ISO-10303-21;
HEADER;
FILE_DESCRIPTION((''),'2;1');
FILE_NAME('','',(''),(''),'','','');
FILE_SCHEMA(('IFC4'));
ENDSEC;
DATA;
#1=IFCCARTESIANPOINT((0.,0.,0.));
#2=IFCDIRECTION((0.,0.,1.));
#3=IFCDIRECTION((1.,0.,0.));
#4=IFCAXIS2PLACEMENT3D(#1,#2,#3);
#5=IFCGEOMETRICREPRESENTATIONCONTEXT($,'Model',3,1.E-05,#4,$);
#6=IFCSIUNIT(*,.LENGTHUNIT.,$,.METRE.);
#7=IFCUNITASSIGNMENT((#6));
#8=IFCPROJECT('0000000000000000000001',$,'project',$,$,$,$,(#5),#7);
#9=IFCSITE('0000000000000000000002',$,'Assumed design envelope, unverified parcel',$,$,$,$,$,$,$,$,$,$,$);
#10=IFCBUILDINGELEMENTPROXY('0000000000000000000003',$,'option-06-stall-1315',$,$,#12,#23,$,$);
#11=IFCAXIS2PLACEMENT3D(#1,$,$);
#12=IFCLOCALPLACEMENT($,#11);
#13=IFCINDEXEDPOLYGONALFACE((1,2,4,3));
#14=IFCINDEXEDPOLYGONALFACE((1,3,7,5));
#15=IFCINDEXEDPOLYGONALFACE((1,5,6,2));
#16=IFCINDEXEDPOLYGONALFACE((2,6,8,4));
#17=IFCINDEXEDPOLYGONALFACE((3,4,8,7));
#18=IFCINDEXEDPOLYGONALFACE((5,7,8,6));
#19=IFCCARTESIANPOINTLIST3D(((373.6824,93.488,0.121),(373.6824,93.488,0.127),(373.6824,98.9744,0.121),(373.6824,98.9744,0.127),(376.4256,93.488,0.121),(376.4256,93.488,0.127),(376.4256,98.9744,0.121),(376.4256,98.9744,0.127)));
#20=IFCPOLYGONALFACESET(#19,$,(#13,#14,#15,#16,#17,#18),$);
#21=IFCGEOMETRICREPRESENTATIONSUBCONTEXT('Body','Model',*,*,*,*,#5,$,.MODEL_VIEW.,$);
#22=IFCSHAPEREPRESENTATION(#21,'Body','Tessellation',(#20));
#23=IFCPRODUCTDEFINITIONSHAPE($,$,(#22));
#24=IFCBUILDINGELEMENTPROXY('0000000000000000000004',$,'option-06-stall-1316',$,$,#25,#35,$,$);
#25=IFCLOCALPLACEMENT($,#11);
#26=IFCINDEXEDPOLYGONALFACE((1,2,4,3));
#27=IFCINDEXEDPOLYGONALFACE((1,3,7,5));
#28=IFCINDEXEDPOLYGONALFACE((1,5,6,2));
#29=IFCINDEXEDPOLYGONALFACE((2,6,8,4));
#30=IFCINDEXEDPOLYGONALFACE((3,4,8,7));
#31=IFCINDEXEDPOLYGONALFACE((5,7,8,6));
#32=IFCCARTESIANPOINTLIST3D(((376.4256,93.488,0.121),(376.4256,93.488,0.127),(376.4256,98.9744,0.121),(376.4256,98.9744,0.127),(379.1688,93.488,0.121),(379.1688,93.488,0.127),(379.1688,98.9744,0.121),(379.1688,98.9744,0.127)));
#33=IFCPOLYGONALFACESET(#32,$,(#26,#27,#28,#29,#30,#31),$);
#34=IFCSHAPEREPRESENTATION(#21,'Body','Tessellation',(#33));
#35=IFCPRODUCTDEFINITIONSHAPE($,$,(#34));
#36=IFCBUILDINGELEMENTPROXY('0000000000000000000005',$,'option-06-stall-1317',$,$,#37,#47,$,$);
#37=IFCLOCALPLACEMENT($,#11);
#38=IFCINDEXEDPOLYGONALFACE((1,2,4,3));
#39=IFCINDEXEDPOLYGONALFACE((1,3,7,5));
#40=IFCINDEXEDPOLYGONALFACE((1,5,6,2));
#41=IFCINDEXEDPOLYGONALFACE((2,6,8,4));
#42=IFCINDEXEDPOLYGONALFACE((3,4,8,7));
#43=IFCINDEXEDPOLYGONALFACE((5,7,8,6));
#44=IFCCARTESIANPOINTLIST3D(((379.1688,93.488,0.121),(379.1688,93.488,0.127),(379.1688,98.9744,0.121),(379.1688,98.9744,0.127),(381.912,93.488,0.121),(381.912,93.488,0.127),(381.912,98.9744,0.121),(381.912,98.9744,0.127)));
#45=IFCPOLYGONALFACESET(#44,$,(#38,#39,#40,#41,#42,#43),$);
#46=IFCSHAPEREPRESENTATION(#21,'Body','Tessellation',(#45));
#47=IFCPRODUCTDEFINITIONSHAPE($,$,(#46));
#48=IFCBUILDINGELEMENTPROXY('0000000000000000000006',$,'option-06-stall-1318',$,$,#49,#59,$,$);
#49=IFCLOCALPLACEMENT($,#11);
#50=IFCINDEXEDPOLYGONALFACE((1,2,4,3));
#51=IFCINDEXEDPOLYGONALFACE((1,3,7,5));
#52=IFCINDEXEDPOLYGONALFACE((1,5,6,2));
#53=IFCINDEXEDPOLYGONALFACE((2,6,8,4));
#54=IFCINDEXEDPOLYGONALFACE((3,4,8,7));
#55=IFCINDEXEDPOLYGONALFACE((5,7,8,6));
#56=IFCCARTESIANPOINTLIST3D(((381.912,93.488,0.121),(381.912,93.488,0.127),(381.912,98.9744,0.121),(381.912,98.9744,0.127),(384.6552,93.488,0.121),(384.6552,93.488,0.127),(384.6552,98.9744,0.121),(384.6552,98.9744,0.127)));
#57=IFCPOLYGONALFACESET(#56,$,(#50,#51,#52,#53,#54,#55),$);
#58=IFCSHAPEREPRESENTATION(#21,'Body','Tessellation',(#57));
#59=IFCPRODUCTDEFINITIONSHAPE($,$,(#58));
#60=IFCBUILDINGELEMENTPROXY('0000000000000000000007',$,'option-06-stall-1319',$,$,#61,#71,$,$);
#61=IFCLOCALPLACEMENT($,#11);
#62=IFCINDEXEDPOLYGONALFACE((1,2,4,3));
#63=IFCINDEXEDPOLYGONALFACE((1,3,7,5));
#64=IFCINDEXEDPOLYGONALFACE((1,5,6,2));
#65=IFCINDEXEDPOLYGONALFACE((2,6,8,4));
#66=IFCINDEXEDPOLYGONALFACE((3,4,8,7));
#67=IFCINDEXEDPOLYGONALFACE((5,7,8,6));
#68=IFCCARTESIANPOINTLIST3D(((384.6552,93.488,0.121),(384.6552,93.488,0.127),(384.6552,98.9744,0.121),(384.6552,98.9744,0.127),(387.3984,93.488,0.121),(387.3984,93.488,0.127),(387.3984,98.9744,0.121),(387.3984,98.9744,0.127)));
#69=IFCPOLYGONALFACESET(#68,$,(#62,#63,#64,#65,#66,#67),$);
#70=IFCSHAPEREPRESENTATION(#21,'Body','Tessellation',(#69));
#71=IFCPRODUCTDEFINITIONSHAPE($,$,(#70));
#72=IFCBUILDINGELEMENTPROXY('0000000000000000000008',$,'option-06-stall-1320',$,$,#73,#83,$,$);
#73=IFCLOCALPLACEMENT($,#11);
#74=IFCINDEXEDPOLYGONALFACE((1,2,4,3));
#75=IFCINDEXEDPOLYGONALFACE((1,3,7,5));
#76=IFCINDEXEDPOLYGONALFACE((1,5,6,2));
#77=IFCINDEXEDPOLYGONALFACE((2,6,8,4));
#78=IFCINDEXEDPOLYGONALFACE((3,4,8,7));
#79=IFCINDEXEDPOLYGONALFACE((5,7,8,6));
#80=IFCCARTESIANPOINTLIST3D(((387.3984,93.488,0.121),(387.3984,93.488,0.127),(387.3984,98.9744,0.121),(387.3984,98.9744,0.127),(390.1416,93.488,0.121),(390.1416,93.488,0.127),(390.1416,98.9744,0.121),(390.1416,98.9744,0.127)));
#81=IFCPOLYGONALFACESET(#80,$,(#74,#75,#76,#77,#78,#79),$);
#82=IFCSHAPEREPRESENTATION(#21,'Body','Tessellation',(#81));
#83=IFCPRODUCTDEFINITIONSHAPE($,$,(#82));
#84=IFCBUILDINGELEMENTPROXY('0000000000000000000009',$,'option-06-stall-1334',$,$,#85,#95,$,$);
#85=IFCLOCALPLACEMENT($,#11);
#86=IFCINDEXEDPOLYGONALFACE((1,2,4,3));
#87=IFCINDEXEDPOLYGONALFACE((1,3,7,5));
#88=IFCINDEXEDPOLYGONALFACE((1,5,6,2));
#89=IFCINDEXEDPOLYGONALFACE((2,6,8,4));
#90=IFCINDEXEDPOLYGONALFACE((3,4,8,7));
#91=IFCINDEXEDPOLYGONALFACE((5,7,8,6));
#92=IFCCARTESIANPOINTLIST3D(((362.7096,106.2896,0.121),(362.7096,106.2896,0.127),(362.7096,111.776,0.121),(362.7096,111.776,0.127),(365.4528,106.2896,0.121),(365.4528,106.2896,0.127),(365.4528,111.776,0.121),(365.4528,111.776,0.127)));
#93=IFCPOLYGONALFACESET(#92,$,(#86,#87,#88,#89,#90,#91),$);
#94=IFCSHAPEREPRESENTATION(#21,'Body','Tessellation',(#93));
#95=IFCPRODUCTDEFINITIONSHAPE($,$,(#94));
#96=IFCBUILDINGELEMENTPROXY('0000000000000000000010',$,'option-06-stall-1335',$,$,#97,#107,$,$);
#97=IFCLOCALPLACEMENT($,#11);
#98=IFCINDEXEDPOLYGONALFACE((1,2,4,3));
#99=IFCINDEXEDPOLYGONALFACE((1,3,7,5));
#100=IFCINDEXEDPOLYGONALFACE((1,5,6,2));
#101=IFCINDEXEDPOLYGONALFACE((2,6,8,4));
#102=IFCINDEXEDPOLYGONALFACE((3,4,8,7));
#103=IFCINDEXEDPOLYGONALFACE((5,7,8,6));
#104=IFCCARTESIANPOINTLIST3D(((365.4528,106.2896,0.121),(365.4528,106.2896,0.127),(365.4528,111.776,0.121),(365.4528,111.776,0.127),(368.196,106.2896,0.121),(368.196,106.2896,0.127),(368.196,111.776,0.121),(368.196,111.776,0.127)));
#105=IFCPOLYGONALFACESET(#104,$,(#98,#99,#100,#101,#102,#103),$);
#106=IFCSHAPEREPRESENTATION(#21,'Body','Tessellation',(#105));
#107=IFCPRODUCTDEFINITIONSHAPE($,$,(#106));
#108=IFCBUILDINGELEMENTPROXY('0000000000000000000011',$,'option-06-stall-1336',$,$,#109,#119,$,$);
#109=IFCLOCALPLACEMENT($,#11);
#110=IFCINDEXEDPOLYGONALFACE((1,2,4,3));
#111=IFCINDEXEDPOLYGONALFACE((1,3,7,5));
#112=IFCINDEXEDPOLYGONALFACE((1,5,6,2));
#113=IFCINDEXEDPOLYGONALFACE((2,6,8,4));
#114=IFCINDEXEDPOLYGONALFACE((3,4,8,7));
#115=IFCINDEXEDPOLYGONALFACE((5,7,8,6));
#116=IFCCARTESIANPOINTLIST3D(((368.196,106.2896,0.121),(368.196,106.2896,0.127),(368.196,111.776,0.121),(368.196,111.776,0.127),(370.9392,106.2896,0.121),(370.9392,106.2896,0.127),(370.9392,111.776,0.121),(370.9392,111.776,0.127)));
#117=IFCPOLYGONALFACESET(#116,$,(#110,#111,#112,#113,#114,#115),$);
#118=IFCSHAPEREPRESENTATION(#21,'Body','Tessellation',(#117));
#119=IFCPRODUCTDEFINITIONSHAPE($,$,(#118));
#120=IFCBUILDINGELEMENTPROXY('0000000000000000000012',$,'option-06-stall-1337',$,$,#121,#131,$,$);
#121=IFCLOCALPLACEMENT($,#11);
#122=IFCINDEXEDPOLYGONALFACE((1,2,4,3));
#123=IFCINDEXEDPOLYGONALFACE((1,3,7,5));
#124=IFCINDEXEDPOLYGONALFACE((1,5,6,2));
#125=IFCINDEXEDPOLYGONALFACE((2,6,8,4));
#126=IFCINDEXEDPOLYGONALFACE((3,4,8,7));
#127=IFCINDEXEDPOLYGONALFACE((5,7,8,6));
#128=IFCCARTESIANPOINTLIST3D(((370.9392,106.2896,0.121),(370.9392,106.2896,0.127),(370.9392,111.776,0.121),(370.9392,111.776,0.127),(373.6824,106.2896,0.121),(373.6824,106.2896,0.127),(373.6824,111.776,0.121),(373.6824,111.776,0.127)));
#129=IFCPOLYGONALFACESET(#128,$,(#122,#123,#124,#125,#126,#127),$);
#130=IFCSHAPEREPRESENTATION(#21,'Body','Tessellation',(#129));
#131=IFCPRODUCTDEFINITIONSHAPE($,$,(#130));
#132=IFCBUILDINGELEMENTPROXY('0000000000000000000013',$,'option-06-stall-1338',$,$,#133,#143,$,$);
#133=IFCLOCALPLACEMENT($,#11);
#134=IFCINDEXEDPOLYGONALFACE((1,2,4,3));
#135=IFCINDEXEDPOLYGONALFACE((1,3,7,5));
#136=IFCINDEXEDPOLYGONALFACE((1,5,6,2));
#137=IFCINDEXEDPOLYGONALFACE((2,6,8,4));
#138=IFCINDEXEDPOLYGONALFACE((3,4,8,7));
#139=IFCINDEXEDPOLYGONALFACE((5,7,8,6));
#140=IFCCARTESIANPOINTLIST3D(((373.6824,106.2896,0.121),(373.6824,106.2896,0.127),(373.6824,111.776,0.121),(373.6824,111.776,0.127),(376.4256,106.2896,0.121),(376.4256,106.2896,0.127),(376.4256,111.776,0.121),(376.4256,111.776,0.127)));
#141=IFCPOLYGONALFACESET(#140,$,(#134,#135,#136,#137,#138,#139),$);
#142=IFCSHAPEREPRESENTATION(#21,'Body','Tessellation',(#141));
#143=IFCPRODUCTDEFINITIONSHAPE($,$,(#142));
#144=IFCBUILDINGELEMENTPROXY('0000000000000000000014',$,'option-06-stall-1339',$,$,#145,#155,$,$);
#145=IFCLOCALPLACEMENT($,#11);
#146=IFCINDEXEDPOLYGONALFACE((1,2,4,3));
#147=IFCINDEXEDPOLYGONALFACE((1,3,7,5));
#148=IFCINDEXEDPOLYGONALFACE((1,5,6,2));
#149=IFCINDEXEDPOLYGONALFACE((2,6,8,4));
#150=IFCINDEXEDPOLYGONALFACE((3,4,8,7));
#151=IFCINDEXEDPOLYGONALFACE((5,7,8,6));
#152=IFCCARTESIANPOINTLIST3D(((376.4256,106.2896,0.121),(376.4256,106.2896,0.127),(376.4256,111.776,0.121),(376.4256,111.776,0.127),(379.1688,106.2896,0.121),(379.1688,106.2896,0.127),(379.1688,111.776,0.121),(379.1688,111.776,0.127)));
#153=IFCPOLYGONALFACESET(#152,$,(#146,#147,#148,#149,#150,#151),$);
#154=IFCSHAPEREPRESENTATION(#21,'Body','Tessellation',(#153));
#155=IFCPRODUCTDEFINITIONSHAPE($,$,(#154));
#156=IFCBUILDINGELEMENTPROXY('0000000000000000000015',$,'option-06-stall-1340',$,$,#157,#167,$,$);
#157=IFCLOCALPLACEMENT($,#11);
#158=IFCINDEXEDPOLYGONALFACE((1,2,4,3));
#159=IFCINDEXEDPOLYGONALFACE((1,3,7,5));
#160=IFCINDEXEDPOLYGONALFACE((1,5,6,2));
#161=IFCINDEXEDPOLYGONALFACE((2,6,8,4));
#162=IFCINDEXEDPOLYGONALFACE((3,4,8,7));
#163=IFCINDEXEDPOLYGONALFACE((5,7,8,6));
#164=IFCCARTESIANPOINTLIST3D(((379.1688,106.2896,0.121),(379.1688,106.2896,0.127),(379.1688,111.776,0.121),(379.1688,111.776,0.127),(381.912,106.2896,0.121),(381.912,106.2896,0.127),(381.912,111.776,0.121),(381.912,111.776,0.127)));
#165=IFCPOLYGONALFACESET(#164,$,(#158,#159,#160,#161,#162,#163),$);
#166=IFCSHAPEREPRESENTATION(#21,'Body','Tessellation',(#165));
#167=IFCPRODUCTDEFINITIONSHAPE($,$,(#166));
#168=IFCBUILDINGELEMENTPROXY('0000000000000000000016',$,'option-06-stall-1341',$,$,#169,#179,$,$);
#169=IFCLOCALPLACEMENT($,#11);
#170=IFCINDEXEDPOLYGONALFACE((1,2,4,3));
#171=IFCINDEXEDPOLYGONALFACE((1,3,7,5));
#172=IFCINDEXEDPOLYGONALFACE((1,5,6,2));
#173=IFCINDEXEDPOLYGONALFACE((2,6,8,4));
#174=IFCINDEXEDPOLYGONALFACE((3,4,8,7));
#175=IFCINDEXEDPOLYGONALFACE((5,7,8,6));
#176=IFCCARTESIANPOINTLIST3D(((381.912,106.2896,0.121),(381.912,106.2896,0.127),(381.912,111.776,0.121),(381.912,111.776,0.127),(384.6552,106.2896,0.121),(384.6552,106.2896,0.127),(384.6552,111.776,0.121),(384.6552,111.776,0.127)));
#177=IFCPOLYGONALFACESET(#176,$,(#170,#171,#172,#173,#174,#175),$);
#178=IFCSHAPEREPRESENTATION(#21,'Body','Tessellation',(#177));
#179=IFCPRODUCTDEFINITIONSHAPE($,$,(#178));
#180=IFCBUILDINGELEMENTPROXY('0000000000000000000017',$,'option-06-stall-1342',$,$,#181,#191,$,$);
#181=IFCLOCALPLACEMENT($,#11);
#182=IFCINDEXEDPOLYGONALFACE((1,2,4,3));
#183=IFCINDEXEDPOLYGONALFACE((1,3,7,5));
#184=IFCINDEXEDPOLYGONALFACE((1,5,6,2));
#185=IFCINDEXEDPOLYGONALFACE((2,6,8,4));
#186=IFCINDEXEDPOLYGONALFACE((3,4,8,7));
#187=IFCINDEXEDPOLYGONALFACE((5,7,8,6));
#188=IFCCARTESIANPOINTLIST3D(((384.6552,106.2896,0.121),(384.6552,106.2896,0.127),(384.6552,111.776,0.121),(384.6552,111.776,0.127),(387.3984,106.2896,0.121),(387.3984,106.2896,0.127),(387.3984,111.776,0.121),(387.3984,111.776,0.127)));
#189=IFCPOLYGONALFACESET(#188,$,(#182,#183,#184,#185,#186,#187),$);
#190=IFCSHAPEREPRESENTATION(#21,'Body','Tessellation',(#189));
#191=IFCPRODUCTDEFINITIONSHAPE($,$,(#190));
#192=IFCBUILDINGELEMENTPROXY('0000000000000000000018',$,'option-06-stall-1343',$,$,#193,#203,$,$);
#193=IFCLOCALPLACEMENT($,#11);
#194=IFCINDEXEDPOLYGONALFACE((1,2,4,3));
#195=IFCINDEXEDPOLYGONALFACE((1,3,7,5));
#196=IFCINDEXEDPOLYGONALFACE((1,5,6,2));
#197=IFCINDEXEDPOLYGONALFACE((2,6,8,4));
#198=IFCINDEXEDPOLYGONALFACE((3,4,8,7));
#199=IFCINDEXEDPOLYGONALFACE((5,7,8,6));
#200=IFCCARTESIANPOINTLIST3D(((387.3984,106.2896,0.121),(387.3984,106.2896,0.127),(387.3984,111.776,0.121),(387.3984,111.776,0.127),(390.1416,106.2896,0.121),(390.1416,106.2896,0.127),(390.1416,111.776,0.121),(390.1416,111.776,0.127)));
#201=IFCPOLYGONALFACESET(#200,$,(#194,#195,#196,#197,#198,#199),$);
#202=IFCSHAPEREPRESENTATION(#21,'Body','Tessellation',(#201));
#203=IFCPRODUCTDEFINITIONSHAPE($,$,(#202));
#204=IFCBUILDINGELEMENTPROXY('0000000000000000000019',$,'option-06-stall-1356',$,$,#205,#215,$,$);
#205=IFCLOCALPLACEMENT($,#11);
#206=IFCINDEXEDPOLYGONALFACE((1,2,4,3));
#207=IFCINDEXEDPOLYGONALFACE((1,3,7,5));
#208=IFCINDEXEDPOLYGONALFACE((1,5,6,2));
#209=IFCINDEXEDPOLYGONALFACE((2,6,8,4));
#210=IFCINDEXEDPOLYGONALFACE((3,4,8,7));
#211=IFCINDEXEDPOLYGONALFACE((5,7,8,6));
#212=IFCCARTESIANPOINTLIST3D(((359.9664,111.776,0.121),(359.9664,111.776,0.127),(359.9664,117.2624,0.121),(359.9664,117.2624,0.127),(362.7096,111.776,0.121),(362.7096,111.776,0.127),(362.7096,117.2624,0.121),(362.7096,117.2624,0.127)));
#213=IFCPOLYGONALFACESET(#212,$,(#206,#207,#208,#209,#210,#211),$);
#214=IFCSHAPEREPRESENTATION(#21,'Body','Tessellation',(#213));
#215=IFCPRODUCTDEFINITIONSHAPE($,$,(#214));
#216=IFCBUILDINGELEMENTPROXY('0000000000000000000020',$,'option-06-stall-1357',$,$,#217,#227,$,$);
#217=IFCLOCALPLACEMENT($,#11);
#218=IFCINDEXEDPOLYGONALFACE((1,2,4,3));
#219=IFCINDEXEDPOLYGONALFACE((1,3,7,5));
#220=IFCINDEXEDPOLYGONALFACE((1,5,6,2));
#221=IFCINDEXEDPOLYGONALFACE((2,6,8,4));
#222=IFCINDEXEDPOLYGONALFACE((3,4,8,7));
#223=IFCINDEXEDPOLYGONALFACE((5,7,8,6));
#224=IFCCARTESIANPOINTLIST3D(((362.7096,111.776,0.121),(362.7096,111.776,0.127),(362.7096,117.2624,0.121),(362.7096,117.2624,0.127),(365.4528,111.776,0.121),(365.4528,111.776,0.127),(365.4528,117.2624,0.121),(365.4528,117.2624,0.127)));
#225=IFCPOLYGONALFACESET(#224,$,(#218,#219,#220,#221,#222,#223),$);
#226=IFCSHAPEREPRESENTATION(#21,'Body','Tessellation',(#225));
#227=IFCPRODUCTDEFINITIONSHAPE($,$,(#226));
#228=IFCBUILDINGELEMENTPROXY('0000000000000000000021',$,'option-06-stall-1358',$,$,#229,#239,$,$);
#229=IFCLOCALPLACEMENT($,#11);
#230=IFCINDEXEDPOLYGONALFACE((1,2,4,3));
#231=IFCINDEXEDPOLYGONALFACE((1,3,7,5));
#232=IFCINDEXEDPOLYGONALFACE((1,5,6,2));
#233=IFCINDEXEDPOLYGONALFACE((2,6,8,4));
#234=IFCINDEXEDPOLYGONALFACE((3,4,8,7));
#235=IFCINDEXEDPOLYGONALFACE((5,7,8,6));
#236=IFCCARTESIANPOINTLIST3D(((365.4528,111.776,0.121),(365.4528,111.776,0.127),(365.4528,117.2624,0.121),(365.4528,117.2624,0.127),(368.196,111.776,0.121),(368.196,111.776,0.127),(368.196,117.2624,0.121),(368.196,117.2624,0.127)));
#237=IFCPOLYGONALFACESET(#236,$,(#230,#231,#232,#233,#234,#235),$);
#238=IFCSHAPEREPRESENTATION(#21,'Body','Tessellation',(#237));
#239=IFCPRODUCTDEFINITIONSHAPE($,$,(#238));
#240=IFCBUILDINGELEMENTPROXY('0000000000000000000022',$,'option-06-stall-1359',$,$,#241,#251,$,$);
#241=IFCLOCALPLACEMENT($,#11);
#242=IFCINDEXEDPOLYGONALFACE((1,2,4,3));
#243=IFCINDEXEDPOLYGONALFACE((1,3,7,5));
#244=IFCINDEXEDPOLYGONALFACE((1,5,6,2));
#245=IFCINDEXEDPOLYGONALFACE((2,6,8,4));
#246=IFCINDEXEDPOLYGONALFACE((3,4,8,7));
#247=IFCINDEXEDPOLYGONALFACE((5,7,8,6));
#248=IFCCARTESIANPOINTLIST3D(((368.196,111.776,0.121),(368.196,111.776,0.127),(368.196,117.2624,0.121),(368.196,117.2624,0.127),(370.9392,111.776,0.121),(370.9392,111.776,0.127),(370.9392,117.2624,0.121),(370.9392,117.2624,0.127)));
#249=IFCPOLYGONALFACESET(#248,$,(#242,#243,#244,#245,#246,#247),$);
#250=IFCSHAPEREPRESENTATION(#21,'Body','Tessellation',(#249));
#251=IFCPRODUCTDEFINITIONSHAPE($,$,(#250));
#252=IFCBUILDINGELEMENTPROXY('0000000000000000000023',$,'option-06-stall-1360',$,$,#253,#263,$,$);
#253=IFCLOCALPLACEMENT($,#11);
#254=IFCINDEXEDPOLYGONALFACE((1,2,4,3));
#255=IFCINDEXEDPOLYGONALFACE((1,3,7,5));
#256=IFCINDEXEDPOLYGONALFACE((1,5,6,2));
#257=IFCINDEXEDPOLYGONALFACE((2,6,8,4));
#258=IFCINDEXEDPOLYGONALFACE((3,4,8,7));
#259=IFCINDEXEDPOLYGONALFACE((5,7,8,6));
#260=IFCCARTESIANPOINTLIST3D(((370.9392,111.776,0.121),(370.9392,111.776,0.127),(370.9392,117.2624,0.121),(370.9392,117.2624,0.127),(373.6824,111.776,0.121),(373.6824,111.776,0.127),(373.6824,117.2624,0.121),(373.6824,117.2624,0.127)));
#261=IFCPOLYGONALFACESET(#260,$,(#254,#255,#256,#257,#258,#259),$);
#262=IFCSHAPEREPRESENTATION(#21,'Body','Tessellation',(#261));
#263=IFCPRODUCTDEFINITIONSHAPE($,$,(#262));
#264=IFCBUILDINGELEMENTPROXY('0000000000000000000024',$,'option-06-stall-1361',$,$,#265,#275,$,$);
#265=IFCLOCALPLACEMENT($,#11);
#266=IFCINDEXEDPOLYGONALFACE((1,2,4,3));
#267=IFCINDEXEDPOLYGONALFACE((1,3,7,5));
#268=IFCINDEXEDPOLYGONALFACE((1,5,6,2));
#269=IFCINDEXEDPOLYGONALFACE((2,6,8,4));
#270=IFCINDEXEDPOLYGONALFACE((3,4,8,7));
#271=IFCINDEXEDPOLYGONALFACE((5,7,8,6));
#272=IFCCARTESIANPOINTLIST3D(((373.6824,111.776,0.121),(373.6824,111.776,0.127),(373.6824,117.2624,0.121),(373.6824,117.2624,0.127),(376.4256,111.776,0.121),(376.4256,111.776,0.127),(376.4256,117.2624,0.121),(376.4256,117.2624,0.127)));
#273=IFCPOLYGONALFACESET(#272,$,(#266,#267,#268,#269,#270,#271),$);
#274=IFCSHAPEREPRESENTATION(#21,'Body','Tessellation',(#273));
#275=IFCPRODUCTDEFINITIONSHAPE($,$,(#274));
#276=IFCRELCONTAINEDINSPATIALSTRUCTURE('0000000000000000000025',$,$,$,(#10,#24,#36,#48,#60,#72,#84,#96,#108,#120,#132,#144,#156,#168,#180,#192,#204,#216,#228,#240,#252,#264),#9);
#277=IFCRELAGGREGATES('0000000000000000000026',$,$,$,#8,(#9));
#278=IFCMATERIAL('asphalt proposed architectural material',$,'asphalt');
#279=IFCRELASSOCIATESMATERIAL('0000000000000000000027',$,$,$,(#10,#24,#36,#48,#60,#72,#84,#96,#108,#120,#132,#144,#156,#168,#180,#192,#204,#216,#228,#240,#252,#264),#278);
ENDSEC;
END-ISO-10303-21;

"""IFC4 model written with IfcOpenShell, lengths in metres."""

from ifc_helpers import new_model, si_unit, frame, origin_with_axes, place, context, subcontext, project, spatial, rectangle, extrude, material, element, save


model = new_model("IFC4")

# Units and contexts
model_context = context("Model", 3, precision=1e-05, world=origin_with_axes())
body_context = subcontext(model_context, "Body", "Model", "MODEL_VIEW")
ifc_project = project(units=[si_unit("LENGTHUNIT", "METRE")], contexts=[model_context])

# Site
site = spatial("IfcSite", under=ifc_project, Name="Assumed design envelope, unverified parcel")

# Building element proxies
ifc_material = material(Name="asphalt proposed architectural material", Category="asphalt")
for number, where, z_axis, x_axis, name in (
    (1, (375.054, 96.2312, 0.121), (0.0, 0.0, 1.0), (1.0, 0.0, 0.0), "option-06-stall-1315"),
    (2, (377.7972, 96.2312, 0.121), (0.0, 0.0, 1.0), (1.0, 0.0, 0.0), "option-06-stall-1316"),
    (3, (380.5404, 96.2312, 0.121), (0.0, 0.0, 1.0), (1.0, 0.0, 0.0), "option-06-stall-1317"),
    (4, (383.2836, 96.2312, 0.121), (0.0, 0.0, 1.0), (1.0, 0.0, 0.0), "option-06-stall-1318"),
    (5, (386.0268, 96.2312, 0.121), (0.0, 0.0, 1.0), (1.0, 0.0, 0.0), "option-06-stall-1319"),
    (6, (388.77, 96.2312, 0.121), (0.0, 0.0, 1.0), (1.0, 0.0, 0.0), "option-06-stall-1320"),
    (7, (364.0812, 109.0328, 0.121), (0.0, 0.0, 1.0), (1.0, 0.0, 0.0), "option-06-stall-1334"),
    (8, (366.8244, 109.0328, 0.121), (0.0, 0.0, 1.0), (1.0, 0.0, 0.0), "option-06-stall-1335"),
    (9, (369.5676, 109.0328, 0.121), (0.0, 0.0, 1.0), (1.0, 0.0, 0.0), "option-06-stall-1336"),
    (10, (372.3108, 109.0328, 0.121), (0.0, 0.0, 1.0), (1.0, 0.0, 0.0), "option-06-stall-1337"),
    (11, (375.054, 109.0328, 0.121), (0.0, 0.0, 1.0), (1.0, 0.0, 0.0), "option-06-stall-1338"),
    (12, (377.7972, 109.0328, 0.121), (0.0, 0.0, 1.0), (1.0, 0.0, 0.0), "option-06-stall-1339"),
    (13, (380.5404, 109.0328, 0.121), (0.0, 0.0, 1.0), (1.0, 0.0, 0.0), "option-06-stall-1340"),
    (14, (383.2836, 109.0328, 0.121), (0.0, 0.0, 1.0), (1.0, 0.0, 0.0), "option-06-stall-1341"),
    (15, (386.0268, 109.0328, 0.121), (0.0, 0.0, 1.0), (1.0, 0.0, 0.0), "option-06-stall-1342"),
    (16, (388.77, 109.0328, 0.121), (0.0, 0.0, 1.0), (1.0, 0.0, 0.0), "option-06-stall-1343"),
    (17, (361.338, 114.5192, 0.121), (0.0, 0.0, 1.0), (1.0, 0.0, 0.0), "option-06-stall-1356"),
    (18, (364.0812, 114.5192, 0.121), (0.0, 0.0, 1.0), (1.0, 0.0, 0.0), "option-06-stall-1357"),
    (19, (366.8244, 114.5192, 0.121), (0.0, 0.0, 1.0), (1.0, 0.0, 0.0), "option-06-stall-1358"),
    (20, (369.5676, 114.5192, 0.121), (0.0, 0.0, 1.0), (1.0, 0.0, 0.0), "option-06-stall-1359"),
    (21, (372.3108, 114.5192, 0.121), (0.0, 0.0, 1.0), (1.0, 0.0, 0.0), "option-06-stall-1360"),
    (22, (375.054, 114.5192, 0.121), (0.0, 0.0, 1.0), (1.0, 0.0, 0.0), "option-06-stall-1361"),
):
    element("IfcBuildingElementProxy", number, at=place(None, frame(where, z_axis=z_axis, x_axis=x_axis)), inside=site, material=ifc_material, Name=name, context=body_context, shape_type="SweptSolid", body=[
        extrude(rectangle(XDim=2.7432, YDim=5.4864), origin_with_axes(), (0.0, 0.0, 1.0), 0.006),
    ])

save(model, "model.ifc")
